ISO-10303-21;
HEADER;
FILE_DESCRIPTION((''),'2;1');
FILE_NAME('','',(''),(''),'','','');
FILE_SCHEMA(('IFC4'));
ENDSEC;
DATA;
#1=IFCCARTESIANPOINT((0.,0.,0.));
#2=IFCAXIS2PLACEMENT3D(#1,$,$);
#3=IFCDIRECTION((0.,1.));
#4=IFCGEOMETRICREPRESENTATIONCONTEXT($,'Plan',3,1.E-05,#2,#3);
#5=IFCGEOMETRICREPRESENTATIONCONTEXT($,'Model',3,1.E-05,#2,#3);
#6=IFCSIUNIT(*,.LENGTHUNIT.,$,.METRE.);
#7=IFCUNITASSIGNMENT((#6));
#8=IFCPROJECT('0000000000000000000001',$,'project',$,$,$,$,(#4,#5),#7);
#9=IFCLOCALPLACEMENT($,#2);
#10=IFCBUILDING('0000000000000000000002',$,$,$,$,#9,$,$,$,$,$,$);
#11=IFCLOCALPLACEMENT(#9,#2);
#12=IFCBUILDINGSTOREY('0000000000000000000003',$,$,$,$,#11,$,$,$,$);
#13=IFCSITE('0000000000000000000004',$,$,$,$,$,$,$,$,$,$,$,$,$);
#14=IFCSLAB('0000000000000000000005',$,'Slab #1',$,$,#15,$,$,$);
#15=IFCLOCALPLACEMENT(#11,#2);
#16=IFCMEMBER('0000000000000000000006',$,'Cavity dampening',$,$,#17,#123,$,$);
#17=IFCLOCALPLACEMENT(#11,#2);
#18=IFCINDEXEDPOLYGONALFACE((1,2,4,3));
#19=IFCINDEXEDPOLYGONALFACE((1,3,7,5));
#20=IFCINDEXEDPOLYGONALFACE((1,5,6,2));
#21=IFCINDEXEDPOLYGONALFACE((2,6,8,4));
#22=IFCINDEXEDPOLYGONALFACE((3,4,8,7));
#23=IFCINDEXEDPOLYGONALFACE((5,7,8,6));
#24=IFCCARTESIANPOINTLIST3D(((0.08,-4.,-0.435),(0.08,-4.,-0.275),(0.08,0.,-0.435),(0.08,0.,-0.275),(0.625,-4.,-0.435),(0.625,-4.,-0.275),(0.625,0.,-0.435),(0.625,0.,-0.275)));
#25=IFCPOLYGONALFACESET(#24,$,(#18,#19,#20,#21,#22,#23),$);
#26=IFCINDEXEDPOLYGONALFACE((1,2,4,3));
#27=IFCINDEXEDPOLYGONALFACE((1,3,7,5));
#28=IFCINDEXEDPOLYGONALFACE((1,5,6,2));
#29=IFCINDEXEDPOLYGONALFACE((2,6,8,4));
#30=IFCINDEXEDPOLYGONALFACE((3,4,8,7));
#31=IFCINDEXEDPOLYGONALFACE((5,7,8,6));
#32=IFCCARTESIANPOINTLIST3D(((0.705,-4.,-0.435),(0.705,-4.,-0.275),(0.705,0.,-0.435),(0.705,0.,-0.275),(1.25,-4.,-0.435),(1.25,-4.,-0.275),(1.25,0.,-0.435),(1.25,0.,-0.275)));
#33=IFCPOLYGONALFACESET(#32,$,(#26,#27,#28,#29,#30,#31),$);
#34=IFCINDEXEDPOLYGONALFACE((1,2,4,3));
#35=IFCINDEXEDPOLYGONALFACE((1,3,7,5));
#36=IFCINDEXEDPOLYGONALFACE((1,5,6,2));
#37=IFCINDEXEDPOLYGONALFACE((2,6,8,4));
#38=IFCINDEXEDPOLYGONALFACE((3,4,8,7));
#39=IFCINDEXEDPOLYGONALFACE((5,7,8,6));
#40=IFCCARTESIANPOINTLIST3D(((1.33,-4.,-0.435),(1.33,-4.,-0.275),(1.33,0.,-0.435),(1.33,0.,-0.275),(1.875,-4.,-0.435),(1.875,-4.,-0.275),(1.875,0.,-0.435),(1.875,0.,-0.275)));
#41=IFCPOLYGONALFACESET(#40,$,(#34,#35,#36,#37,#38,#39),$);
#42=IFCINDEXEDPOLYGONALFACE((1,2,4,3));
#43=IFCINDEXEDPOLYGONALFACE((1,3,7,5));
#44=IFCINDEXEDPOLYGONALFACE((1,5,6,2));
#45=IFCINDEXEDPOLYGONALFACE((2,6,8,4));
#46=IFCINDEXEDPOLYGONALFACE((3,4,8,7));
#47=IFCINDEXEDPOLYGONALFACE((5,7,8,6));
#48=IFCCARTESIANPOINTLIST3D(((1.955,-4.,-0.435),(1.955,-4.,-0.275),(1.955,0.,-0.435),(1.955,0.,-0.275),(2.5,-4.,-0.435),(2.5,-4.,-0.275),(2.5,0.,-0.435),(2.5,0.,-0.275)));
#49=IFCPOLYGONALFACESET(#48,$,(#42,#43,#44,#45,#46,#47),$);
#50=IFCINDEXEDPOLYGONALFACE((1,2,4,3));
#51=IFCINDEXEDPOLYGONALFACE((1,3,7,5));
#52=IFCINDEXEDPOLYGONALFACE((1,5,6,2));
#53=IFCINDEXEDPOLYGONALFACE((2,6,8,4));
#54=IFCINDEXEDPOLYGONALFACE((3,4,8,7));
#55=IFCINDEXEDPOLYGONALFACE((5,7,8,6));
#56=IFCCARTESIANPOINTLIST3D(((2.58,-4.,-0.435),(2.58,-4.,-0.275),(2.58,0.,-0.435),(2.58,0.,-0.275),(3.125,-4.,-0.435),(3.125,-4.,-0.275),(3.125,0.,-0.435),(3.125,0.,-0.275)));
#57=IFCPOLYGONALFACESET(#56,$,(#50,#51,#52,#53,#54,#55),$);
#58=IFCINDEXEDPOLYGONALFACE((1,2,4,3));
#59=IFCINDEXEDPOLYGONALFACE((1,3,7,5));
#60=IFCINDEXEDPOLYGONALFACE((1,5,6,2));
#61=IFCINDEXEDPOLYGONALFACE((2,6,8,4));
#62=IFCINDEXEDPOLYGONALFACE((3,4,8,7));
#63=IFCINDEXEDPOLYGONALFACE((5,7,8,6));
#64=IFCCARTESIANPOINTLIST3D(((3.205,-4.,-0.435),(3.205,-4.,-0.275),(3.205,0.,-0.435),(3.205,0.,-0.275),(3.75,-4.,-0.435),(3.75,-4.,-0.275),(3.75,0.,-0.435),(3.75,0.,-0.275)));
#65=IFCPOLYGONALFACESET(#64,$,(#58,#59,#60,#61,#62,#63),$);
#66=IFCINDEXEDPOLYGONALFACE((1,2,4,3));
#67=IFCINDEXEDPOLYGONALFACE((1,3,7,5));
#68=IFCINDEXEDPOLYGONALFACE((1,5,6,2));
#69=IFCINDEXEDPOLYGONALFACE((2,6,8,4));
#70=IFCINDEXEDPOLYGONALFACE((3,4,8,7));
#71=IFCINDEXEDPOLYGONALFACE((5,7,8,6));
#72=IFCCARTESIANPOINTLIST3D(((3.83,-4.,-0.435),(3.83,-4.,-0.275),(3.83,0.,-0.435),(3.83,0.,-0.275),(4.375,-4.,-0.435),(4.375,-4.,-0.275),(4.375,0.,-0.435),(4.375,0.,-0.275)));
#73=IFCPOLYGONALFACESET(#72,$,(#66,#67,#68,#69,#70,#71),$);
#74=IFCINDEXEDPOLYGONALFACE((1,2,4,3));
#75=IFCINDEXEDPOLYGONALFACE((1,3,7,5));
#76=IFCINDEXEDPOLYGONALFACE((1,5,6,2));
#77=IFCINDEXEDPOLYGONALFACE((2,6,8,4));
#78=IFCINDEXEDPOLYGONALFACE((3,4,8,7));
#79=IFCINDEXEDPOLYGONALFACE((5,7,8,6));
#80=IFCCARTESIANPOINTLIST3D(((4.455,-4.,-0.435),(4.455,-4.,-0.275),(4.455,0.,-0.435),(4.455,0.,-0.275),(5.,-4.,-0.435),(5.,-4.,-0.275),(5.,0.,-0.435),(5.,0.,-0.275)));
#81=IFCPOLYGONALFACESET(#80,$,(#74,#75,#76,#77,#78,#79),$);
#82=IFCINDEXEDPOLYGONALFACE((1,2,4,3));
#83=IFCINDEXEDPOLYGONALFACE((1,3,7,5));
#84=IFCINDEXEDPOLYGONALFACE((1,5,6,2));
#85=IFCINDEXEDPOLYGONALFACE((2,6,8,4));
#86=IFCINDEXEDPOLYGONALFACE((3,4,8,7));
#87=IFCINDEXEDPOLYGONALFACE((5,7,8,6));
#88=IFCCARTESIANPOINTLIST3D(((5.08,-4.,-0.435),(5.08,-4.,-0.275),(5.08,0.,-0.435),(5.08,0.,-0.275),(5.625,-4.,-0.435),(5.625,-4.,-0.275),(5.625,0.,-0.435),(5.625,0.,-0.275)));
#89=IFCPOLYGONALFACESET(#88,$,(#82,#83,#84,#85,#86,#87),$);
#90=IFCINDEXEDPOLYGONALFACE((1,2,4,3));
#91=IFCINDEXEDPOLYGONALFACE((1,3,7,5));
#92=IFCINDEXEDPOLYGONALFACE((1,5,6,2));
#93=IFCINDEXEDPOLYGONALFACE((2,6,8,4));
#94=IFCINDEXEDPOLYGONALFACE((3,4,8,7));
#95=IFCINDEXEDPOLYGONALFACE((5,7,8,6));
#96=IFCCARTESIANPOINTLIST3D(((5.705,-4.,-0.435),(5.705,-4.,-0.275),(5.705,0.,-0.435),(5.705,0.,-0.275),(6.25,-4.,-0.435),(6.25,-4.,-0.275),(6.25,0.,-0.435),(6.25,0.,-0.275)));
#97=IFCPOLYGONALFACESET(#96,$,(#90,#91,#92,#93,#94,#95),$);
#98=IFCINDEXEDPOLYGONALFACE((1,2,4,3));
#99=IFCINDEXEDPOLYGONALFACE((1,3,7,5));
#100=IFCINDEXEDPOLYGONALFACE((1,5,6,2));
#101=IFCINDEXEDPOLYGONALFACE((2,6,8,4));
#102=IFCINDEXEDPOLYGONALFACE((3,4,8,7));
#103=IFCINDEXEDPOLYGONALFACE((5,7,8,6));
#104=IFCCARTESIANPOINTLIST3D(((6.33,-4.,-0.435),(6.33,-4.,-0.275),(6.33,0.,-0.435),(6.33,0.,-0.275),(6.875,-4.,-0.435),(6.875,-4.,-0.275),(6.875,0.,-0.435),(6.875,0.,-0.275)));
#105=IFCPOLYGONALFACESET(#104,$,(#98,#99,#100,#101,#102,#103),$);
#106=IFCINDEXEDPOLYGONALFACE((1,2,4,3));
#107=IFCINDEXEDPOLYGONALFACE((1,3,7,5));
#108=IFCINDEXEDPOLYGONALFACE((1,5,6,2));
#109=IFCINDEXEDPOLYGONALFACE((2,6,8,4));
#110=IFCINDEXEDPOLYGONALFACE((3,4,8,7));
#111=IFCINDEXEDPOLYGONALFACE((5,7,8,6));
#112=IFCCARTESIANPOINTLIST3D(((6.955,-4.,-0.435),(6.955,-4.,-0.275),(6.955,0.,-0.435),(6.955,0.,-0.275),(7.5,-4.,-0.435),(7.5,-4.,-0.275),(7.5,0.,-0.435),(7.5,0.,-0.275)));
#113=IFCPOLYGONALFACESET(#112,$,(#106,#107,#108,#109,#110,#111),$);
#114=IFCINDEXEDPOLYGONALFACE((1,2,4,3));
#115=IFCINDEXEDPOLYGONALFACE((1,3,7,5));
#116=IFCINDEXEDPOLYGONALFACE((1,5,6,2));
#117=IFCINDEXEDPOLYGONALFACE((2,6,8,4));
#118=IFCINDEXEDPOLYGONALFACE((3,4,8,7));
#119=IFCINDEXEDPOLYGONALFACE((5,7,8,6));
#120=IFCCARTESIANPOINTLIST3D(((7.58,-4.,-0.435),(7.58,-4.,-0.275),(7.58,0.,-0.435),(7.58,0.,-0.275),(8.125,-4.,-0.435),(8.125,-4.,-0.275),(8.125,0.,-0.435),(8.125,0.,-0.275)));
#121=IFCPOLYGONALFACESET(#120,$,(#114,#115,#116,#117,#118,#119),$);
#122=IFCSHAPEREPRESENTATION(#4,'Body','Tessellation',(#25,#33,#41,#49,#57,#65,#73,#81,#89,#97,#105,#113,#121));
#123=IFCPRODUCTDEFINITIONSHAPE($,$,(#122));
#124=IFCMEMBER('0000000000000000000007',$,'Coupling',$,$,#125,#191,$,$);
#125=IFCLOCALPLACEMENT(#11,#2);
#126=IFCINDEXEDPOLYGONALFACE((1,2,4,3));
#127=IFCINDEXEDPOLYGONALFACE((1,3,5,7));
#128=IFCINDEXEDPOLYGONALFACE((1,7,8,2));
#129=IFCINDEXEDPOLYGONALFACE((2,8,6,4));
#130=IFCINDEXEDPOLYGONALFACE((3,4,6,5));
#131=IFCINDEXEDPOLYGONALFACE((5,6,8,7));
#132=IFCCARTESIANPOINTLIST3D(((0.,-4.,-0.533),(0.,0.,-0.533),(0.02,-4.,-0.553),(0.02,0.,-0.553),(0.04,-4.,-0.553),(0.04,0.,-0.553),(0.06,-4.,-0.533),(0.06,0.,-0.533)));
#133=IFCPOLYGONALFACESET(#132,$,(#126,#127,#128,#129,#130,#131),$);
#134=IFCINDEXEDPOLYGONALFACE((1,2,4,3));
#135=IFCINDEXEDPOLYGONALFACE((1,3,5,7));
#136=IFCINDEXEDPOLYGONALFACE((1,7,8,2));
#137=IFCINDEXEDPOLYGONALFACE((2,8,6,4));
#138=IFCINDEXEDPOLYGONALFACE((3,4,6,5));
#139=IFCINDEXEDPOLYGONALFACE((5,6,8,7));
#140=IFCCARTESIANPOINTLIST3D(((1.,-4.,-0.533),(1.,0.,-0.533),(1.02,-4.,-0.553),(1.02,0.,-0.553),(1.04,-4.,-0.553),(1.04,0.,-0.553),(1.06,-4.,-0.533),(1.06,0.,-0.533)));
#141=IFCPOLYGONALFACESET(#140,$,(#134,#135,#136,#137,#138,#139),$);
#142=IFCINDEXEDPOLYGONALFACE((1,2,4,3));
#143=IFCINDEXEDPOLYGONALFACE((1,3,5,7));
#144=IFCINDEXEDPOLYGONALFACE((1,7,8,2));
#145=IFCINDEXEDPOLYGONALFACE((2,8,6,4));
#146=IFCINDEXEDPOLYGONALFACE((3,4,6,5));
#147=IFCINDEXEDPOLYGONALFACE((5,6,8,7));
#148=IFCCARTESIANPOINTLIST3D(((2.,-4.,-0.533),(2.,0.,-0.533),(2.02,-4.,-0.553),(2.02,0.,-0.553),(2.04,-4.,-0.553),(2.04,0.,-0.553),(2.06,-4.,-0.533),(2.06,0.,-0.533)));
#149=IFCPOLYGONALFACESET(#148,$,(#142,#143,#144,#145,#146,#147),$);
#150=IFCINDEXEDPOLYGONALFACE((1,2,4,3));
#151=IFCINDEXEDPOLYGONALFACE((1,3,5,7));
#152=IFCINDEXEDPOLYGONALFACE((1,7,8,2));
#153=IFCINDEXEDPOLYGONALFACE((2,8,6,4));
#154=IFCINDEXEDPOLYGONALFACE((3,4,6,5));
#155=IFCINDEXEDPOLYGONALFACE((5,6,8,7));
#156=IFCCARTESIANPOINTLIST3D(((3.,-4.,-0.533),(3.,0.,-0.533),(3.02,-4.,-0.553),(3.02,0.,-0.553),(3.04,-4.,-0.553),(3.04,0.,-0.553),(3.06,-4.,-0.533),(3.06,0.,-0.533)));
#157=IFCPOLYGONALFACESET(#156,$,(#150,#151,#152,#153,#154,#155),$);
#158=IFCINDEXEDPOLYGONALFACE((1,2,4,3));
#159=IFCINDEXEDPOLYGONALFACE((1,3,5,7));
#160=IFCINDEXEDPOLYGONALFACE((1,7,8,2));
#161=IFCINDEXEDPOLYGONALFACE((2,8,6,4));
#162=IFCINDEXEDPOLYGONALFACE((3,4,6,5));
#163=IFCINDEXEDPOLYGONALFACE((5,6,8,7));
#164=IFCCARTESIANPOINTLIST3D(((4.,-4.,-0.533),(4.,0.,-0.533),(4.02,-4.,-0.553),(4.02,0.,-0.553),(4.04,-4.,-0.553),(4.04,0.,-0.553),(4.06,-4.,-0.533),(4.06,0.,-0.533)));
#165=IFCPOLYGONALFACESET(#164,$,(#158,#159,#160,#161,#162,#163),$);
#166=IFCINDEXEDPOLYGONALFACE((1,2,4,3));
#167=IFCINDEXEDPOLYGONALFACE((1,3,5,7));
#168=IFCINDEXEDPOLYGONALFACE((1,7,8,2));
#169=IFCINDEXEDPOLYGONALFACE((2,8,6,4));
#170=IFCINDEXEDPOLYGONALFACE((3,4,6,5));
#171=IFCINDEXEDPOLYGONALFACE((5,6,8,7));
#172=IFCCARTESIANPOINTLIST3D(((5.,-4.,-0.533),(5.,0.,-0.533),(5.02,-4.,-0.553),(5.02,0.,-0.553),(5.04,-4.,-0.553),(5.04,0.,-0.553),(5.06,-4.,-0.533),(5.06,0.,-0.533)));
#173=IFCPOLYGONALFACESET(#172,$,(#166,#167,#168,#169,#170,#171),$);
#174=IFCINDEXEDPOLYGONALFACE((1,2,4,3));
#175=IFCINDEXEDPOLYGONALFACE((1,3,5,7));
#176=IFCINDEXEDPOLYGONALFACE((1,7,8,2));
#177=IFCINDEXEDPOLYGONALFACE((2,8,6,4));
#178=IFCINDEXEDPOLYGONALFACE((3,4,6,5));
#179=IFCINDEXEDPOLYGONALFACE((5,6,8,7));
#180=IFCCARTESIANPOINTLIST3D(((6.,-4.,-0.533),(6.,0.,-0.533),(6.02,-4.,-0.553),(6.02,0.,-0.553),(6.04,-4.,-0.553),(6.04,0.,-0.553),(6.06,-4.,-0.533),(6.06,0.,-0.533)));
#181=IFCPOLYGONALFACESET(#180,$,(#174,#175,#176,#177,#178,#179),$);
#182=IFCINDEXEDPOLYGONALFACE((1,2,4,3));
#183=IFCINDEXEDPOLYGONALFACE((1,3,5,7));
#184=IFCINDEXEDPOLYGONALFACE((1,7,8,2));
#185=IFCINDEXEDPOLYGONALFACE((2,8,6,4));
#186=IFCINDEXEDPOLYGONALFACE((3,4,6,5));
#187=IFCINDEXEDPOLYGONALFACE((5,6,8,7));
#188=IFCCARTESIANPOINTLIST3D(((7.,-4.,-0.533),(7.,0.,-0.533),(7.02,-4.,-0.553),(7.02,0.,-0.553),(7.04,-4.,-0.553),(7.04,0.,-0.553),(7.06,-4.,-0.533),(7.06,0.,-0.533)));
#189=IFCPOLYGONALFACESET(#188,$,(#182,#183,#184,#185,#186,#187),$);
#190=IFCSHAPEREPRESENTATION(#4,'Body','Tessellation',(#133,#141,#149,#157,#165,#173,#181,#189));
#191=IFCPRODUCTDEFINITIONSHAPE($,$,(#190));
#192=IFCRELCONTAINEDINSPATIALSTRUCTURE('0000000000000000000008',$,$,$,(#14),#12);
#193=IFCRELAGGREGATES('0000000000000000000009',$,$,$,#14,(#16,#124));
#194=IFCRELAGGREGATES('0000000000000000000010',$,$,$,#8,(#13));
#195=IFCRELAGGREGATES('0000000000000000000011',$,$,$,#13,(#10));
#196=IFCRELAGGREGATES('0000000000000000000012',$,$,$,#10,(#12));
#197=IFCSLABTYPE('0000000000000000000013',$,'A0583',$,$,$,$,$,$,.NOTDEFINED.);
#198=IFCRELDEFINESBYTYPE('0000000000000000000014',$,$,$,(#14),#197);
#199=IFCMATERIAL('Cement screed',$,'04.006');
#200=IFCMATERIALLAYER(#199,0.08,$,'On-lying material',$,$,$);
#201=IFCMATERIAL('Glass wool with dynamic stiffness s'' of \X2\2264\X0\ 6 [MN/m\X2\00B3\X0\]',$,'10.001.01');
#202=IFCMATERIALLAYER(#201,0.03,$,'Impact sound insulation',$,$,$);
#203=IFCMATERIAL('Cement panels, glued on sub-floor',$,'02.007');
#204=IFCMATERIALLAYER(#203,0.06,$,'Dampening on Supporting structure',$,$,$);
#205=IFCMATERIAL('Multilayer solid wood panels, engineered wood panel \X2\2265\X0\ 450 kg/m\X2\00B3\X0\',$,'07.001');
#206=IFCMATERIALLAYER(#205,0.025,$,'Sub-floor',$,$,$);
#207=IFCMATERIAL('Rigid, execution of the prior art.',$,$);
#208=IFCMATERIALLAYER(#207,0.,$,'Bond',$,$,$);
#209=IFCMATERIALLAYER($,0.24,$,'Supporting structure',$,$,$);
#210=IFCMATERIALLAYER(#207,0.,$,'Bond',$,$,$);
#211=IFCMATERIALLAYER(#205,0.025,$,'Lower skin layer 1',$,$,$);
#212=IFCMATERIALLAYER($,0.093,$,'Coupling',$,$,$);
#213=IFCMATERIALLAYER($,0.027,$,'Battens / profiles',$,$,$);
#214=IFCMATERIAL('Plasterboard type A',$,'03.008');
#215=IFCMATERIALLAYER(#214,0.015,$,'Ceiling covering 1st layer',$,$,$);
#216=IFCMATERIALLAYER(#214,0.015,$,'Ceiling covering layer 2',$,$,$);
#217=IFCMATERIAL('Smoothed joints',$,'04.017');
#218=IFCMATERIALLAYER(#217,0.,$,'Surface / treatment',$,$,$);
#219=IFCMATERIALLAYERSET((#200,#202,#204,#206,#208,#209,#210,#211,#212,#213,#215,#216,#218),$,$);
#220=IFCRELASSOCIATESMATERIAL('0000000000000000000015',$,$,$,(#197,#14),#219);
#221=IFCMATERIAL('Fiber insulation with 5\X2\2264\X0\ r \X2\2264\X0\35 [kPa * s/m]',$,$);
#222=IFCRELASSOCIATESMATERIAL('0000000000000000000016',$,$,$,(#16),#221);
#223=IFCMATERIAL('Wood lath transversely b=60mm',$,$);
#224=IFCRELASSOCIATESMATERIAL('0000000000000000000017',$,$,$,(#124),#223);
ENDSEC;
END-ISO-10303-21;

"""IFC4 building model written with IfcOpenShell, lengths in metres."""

from ifc_helpers import new_model, si_unit, direction, frame, frame_2d, origin, place, context, project, spatial, polyline, rectangle, outline, extrude, material, layer, layer_set, type_object, element, aggregate, save


model = new_model("IFC4")

# Units and contexts
plan_context = context("Plan", 3, precision=1e-05, world=origin(), true_north=direction((0.0, 1.0)))
model_context = context("Model", 3, precision=1e-05, world=origin(), true_north=direction((0.0, 1.0)))
ifc_project = project(units=[si_unit("LENGTHUNIT", "METRE")], contexts=[plan_context, model_context])

# Site, building, storey
site = spatial("IfcSite", under=ifc_project)
building_placement = place(None, origin())
building = spatial("IfcBuilding", under=site, at=building_placement)
storey_placement = place(building_placement, origin())
storey = spatial("IfcBuildingStorey", under=building, at=storey_placement)

# Slab, members
ifc_material_1 = material(Name="Cement screed", Category="04.006")
ifc_layer_1 = layer(ifc_material_1, 0.08, Name="On-lying material")
ifc_material_2 = material(Name="Glass wool with dynamic stiffness s' of ≤ 6 [MN/m³]", Category="10.001.01")
ifc_layer_2 = layer(ifc_material_2, 0.03, Name="Impact sound insulation")
ifc_material_3 = material(Name="Cement panels, glued on sub-floor", Category="02.007")
ifc_layer_3 = layer(ifc_material_3, 0.06, Name="Dampening on Supporting structure")
ifc_material_4 = material(Name="Multilayer solid wood panels, engineered wood panel ≥ 450 kg/m³", Category="07.001")
ifc_layer_4 = layer(ifc_material_4, 0.025, Name="Sub-floor")
ifc_material_5 = material(Name="Rigid, execution of the prior art.")
ifc_layer_5 = layer(ifc_material_5, 0.0, Name="Bond")
ifc_layer_6 = layer(None, 0.24, Name="Supporting structure")
ifc_layer_7 = layer(ifc_material_5, 0.0, Name="Bond")
ifc_layer_8 = layer(ifc_material_4, 0.025, Name="Lower skin layer 1")
ifc_layer_9 = layer(None, 0.093, Name="Coupling")
ifc_layer_10 = layer(None, 0.027, Name="Battens / profiles")
ifc_material_6 = material(Name="Plasterboard type A", Category="03.008")
ifc_layer_11 = layer(ifc_material_6, 0.015, Name="Ceiling covering 1st layer")
ifc_layer_12 = layer(ifc_material_6, 0.015, Name="Ceiling covering layer 2")
ifc_material_7 = material(Name="Smoothed joints", Category="04.017")
ifc_layer_13 = layer(ifc_material_7, 0.0, Name="Surface / treatment")
ifc_layer_set = layer_set([ifc_layer_1, ifc_layer_2, ifc_layer_3, ifc_layer_4, ifc_layer_5, ifc_layer_6, ifc_layer_7, ifc_layer_8, ifc_layer_9, ifc_layer_10, ifc_layer_11, ifc_layer_12, ifc_layer_13])
slab_type = type_object("IfcSlabType", Name="A0583", PredefinedType="NOTDEFINED", material=ifc_layer_set)
slab_placement = place(None, frame((0.0, 0.0, 0.0), z_axis=(0.0, 0.0, -1.0), x_axis=(1.0, 0.0, 0.0)))
slab = element("IfcSlab", 1, at=slab_placement, inside=storey, type_object=slab_type, material=ifc_layer_set, Name="Slab #1")
ifc_material_8 = material(Name="Fiber insulation with 5≤ r ≤35 [kPa * s/m]")
member_1_placement = place(slab_placement, origin())
member_1 = element("IfcMember", 2, at=member_1_placement, material=ifc_material_8, Name="Cavity dampening", context=plan_context, shape_type="SweptSolid", body=[
    extrude(rectangle(XDim=0.545, YDim=0.16, at=frame_2d((0.2725, 0.08), x_axis=(1.0, 0.0))), frame((0.08, 4.0, 0.275), z_axis=(0.0, -1.0, 0.0), x_axis=(1.0, 0.0, 0.0)), (0.0, 0.0, 1.0), 4.0),
    extrude(rectangle(XDim=0.545, YDim=0.16, at=frame_2d((0.2725, 0.08), x_axis=(1.0, 0.0))), frame((0.705, 4.0, 0.275), z_axis=(0.0, -1.0, 0.0), x_axis=(1.0, 0.0, 0.0)), (0.0, 0.0, 1.0), 4.0),
    extrude(rectangle(XDim=0.545, YDim=0.16, at=frame_2d((0.2725, 0.08), x_axis=(1.0, 0.0))), frame((1.33, 4.0, 0.275), z_axis=(0.0, -1.0, 0.0), x_axis=(1.0, 0.0, 0.0)), (0.0, 0.0, 1.0), 4.0),
    extrude(rectangle(XDim=0.545, YDim=0.16, at=frame_2d((0.2725, 0.08), x_axis=(1.0, 0.0))), frame((1.955, 4.0, 0.275), z_axis=(0.0, -1.0, 0.0), x_axis=(1.0, 0.0, 0.0)), (0.0, 0.0, 1.0), 4.0),
    extrude(rectangle(XDim=0.545, YDim=0.16, at=frame_2d((0.2725, 0.08), x_axis=(1.0, 0.0))), frame((2.58, 4.0, 0.275), z_axis=(0.0, -1.0, 0.0), x_axis=(1.0, 0.0, 0.0)), (0.0, 0.0, 1.0), 4.0),
    extrude(rectangle(XDim=0.545, YDim=0.16, at=frame_2d((0.2725, 0.08), x_axis=(1.0, 0.0))), frame((3.205, 4.0, 0.275), z_axis=(0.0, -1.0, 0.0), x_axis=(1.0, 0.0, 0.0)), (0.0, 0.0, 1.0), 4.0),
    extrude(rectangle(XDim=0.545, YDim=0.16, at=frame_2d((0.2725, 0.08), x_axis=(1.0, 0.0))), frame((3.83, 4.0, 0.275), z_axis=(0.0, -1.0, 0.0), x_axis=(1.0, 0.0, 0.0)), (0.0, 0.0, 1.0), 4.0),
    extrude(rectangle(XDim=0.545, YDim=0.16, at=frame_2d((0.2725, 0.08), x_axis=(1.0, 0.0))), frame((4.455, 4.0, 0.275), z_axis=(0.0, -1.0, 0.0), x_axis=(1.0, 0.0, 0.0)), (0.0, 0.0, 1.0), 4.0),
    extrude(rectangle(XDim=0.545, YDim=0.16, at=frame_2d((0.2725, 0.08), x_axis=(1.0, 0.0))), frame((5.08, 4.0, 0.275), z_axis=(0.0, -1.0, 0.0), x_axis=(1.0, 0.0, 0.0)), (0.0, 0.0, 1.0), 4.0),
    extrude(rectangle(XDim=0.545, YDim=0.16, at=frame_2d((0.2725, 0.08), x_axis=(1.0, 0.0))), frame((5.705, 4.0, 0.275), z_axis=(0.0, -1.0, 0.0), x_axis=(1.0, 0.0, 0.0)), (0.0, 0.0, 1.0), 4.0),
    extrude(rectangle(XDim=0.545, YDim=0.16, at=frame_2d((0.2725, 0.08), x_axis=(1.0, 0.0))), frame((6.33, 4.0, 0.275), z_axis=(0.0, -1.0, 0.0), x_axis=(1.0, 0.0, 0.0)), (0.0, 0.0, 1.0), 4.0),
    extrude(rectangle(XDim=0.545, YDim=0.16, at=frame_2d((0.2725, 0.08), x_axis=(1.0, 0.0))), frame((6.955, 4.0, 0.275), z_axis=(0.0, -1.0, 0.0), x_axis=(1.0, 0.0, 0.0)), (0.0, 0.0, 1.0), 4.0),
    extrude(rectangle(XDim=0.545, YDim=0.16, at=frame_2d((0.2725, 0.08), x_axis=(1.0, 0.0))), frame((7.58, 4.0, 0.275), z_axis=(0.0, -1.0, 0.0), x_axis=(1.0, 0.0, 0.0)), (0.0, 0.0, 1.0), 4.0),
])
ifc_material_9 = material(Name="Wood lath transversely b=60mm")
member_2_placement = place(slab_placement, origin())
member_2 = element("IfcMember", 3, at=member_2_placement, material=ifc_material_9, Name="Coupling", context=plan_context, shape_type="SweptSolid", body=[
    extrude(outline(polyline([(0.0, 0.0), (0.06, 0.0), (0.04, 0.02), (0.02, 0.02), (0.0, 0.0)])), frame((0.0, 4.0, 0.533), z_axis=(0.0, -1.0, 0.0), x_axis=(1.0, 0.0, 0.0)), (0.0, 0.0, 1.0), 4.0),
    extrude(outline(polyline([(0.0, 0.0), (0.06, 0.0), (0.04, 0.02), (0.02, 0.02), (0.0, 0.0)])), frame((1.0, 4.0, 0.533), z_axis=(0.0, -1.0, 0.0), x_axis=(1.0, 0.0, 0.0)), (0.0, 0.0, 1.0), 4.0),
    extrude(outline(polyline([(0.0, 0.0), (0.06, 0.0), (0.04, 0.02), (0.02, 0.02), (0.0, 0.0)])), frame((2.0, 4.0, 0.533), z_axis=(0.0, -1.0, 0.0), x_axis=(1.0, 0.0, 0.0)), (0.0, 0.0, 1.0), 4.0),
    extrude(outline(polyline([(0.0, 0.0), (0.06, 0.0), (0.04, 0.02), (0.02, 0.02), (0.0, 0.0)])), frame((3.0, 4.0, 0.533), z_axis=(0.0, -1.0, 0.0), x_axis=(1.0, 0.0, 0.0)), (0.0, 0.0, 1.0), 4.0),
    extrude(outline(polyline([(0.0, 0.0), (0.06, 0.0), (0.04, 0.02), (0.02, 0.02), (0.0, 0.0)])), frame((4.0, 4.0, 0.533), z_axis=(0.0, -1.0, 0.0), x_axis=(1.0, 0.0, 0.0)), (0.0, 0.0, 1.0), 4.0),
    extrude(outline(polyline([(0.0, 0.0), (0.06, 0.0), (0.04, 0.02), (0.02, 0.02), (0.0, 0.0)])), frame((5.0, 4.0, 0.533), z_axis=(0.0, -1.0, 0.0), x_axis=(1.0, 0.0, 0.0)), (0.0, 0.0, 1.0), 4.0),
    extrude(outline(polyline([(0.0, 0.0), (0.06, 0.0), (0.04, 0.02), (0.02, 0.02), (0.0, 0.0)])), frame((6.0, 4.0, 0.533), z_axis=(0.0, -1.0, 0.0), x_axis=(1.0, 0.0, 0.0)), (0.0, 0.0, 1.0), 4.0),
    extrude(outline(polyline([(0.0, 0.0), (0.06, 0.0), (0.04, 0.02), (0.02, 0.02), (0.0, 0.0)])), frame((7.0, 4.0, 0.533), z_axis=(0.0, -1.0, 0.0), x_axis=(1.0, 0.0, 0.0)), (0.0, 0.0, 1.0), 4.0),
])
aggregate(slab, [member_1, member_2])

save(model, "model.ifc")
